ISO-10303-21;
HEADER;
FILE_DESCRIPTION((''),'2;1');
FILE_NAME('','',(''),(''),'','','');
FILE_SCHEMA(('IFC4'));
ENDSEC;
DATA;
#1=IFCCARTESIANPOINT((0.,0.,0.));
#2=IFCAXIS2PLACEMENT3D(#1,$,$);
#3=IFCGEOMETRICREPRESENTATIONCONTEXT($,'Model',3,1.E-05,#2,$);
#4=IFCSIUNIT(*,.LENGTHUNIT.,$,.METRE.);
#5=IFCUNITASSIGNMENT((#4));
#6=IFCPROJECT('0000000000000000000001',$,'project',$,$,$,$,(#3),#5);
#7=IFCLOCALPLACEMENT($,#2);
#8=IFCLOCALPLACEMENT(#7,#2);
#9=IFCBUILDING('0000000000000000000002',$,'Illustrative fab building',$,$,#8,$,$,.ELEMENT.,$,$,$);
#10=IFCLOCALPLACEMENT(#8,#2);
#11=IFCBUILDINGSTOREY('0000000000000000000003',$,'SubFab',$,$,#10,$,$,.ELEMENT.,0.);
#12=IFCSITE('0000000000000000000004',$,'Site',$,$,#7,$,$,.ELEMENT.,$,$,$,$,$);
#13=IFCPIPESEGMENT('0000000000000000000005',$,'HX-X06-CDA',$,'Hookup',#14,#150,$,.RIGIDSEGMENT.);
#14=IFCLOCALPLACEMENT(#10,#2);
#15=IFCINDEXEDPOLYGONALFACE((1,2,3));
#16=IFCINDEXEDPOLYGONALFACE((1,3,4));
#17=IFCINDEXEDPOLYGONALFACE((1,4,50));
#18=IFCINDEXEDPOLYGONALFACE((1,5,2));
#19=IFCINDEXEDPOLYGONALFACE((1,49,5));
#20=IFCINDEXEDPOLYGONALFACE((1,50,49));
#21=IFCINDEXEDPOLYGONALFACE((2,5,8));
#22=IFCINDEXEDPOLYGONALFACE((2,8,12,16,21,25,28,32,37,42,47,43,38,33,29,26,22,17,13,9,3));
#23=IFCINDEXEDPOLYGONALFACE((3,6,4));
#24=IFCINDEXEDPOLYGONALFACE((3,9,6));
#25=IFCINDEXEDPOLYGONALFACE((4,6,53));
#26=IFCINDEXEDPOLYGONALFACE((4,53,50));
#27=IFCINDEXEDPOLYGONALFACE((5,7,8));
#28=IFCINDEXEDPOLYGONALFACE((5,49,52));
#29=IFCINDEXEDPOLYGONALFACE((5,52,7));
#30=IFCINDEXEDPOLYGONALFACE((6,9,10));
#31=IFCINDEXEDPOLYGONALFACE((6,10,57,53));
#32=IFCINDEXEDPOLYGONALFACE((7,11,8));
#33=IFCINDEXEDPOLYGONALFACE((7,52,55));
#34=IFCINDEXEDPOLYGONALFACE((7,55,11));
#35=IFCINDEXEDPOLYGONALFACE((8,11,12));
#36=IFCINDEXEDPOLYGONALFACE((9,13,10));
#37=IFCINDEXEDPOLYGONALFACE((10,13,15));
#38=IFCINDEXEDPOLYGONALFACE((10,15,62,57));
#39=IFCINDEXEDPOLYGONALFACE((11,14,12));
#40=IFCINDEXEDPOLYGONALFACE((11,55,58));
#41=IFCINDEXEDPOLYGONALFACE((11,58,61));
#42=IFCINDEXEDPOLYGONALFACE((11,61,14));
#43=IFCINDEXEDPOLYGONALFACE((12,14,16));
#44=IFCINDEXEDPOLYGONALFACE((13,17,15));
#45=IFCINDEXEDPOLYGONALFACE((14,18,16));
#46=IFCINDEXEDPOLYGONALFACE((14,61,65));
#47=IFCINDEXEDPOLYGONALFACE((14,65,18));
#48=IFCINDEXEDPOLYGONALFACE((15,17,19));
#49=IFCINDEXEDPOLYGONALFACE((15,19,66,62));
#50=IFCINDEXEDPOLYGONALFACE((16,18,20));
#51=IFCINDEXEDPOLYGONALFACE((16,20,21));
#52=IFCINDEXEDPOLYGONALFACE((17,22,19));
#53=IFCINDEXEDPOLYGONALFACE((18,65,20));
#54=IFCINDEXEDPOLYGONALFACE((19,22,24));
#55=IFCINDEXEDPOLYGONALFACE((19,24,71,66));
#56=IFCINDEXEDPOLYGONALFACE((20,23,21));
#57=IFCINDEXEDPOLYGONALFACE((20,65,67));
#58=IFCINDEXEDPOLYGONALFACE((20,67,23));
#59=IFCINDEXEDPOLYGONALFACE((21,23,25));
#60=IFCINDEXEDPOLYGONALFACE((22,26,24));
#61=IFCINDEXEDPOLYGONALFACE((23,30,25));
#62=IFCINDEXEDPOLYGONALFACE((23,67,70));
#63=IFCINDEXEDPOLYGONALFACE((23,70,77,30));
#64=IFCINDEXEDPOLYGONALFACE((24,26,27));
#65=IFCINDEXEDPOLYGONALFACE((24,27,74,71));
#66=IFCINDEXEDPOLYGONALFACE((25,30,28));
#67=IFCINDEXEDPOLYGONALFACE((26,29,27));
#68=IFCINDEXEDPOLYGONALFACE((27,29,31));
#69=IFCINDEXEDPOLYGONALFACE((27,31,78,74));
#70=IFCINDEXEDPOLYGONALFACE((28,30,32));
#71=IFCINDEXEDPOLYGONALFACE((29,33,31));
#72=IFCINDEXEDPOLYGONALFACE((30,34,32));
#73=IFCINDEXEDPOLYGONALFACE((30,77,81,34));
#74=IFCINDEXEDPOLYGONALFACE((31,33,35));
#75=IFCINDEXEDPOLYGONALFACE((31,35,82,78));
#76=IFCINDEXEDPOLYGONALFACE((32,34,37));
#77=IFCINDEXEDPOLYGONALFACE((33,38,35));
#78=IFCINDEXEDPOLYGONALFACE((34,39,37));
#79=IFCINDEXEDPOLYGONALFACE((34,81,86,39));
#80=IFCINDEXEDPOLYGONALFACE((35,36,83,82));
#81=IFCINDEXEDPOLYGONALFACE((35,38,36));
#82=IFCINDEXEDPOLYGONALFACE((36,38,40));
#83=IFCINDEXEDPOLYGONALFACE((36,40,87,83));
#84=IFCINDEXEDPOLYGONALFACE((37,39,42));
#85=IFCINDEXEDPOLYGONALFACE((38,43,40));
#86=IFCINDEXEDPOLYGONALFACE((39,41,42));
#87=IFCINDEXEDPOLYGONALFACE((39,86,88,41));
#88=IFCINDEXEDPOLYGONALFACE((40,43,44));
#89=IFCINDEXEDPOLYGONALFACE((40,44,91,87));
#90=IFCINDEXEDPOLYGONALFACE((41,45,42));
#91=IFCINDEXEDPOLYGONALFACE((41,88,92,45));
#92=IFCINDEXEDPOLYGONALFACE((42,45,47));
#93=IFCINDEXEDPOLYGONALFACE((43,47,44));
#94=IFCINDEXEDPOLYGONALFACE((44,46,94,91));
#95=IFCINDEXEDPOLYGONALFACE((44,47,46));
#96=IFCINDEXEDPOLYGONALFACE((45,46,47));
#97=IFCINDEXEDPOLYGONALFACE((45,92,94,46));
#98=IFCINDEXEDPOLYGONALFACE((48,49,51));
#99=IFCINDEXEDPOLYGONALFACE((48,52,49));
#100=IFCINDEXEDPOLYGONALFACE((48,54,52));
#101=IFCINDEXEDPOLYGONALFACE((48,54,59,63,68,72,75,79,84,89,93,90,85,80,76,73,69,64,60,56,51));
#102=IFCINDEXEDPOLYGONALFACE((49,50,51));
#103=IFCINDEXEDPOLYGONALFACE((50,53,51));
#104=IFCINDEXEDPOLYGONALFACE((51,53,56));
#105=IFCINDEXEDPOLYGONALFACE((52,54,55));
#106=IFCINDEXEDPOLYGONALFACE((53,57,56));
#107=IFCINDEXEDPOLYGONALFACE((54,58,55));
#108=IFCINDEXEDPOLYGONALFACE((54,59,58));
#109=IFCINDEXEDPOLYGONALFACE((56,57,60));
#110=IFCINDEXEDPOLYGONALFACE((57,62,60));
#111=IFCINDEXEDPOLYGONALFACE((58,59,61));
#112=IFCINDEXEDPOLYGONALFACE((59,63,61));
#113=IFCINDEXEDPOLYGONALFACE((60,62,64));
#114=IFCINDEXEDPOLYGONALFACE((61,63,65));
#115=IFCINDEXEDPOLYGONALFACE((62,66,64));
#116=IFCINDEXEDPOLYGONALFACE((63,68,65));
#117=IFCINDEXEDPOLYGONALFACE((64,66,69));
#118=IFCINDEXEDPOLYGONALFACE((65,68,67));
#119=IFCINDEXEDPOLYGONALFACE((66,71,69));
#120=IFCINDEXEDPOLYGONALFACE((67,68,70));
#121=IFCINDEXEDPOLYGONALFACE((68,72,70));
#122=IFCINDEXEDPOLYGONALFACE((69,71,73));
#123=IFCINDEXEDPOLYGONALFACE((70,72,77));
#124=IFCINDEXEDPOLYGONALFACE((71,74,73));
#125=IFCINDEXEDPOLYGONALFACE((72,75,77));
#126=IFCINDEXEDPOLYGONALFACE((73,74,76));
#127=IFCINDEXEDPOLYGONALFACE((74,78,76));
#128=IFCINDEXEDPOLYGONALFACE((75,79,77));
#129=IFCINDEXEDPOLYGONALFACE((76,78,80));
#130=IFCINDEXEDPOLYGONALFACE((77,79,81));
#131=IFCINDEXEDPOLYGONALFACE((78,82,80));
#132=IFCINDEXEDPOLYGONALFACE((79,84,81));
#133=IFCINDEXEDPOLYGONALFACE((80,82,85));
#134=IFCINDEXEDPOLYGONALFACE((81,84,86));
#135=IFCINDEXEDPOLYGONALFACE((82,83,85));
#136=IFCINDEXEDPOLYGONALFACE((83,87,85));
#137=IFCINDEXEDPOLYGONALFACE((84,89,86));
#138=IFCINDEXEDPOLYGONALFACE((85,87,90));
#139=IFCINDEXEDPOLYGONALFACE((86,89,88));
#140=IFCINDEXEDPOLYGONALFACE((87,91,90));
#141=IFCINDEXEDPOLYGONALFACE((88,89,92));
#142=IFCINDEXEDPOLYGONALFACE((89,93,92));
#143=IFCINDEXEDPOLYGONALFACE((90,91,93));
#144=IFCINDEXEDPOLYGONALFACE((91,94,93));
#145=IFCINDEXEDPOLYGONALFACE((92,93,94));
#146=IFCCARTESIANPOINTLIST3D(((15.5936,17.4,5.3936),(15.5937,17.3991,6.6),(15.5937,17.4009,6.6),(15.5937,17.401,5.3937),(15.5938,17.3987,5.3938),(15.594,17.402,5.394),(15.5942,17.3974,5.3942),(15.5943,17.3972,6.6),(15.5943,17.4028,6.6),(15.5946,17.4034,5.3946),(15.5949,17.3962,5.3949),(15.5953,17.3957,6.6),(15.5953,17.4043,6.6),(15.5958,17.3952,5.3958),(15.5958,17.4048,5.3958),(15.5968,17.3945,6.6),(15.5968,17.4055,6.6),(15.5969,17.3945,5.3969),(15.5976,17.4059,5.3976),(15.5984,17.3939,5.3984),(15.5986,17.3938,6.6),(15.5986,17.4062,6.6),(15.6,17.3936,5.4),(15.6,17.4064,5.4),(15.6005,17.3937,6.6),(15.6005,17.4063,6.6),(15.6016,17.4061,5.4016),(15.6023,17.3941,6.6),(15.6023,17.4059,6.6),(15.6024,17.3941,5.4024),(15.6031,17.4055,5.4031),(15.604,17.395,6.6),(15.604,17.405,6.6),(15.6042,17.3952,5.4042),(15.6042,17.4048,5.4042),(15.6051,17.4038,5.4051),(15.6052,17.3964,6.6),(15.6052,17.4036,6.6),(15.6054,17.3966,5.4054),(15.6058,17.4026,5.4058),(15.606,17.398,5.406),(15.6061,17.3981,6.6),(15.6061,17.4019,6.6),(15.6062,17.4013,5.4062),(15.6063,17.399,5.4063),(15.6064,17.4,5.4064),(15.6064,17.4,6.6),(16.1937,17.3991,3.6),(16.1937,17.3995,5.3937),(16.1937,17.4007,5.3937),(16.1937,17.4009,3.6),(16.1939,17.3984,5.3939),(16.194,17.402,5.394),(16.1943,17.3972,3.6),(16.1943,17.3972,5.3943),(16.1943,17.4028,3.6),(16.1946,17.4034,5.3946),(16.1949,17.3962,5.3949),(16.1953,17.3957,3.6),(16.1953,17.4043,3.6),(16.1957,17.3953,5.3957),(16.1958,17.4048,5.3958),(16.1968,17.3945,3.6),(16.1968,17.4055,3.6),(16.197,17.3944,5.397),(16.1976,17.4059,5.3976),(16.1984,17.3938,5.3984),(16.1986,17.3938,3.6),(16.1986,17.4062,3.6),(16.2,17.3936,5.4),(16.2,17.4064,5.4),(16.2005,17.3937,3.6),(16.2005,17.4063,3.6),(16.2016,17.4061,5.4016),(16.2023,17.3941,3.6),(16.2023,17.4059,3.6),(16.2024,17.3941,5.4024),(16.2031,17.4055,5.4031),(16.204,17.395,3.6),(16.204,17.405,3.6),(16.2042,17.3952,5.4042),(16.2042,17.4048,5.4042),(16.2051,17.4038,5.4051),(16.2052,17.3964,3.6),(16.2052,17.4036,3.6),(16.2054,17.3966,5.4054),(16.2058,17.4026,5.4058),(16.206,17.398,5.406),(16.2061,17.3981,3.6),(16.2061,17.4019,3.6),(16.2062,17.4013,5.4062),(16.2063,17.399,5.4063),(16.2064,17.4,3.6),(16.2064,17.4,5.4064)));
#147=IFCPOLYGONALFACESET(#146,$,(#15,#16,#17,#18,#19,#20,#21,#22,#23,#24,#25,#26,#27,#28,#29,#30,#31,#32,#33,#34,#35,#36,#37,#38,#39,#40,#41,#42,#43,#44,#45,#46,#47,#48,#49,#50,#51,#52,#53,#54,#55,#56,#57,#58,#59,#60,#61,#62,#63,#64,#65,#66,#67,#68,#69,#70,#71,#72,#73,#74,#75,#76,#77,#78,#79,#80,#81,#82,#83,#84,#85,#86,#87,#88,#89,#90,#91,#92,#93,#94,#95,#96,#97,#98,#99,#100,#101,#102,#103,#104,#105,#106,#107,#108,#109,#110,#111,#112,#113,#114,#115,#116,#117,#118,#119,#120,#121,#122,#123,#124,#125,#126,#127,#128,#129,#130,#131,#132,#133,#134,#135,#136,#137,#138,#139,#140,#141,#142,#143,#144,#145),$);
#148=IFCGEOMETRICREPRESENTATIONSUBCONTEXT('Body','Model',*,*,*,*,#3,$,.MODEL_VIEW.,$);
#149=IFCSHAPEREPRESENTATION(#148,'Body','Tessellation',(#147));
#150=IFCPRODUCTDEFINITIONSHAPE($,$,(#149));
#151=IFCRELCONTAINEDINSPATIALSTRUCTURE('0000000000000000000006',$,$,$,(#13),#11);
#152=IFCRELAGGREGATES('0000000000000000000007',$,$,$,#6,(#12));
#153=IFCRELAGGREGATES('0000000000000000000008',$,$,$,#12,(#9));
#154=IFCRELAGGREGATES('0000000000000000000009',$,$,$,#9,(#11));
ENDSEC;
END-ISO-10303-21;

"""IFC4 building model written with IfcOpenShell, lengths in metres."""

from ifc_helpers import new_model, entity, si_unit, origin, place, context, subcontext, project, spatial, element, save


model = new_model("IFC4")

# Units and contexts
model_context = context("Model", 3, precision=1e-05, world=origin())
body_context = subcontext(model_context, "Body", "Model", "MODEL_VIEW")
ifc_project = project(units=[si_unit("LENGTHUNIT", "METRE")], contexts=[model_context])

# Site, building, storey
site_placement = place(None, origin())
site = spatial("IfcSite", under=ifc_project, at=site_placement, Name="Site", CompositionType="ELEMENT")
building_placement = place(site_placement, origin())
building = spatial("IfcBuilding", under=site, at=building_placement, Name="Illustrative fab building", CompositionType="ELEMENT")
storey_placement = place(building_placement, origin())
storey = spatial("IfcBuildingStorey", under=building, at=storey_placement, Name="SubFab", CompositionType="ELEMENT", Elevation=0.0)

# Pipe segment
pipe_segment_1_placement = place(storey_placement, origin())
element("IfcPipeSegment", 1, at=pipe_segment_1_placement, inside=storey, Name="HX-X06-CDA", ObjectType="Hookup", PredefinedType="RIGIDSEGMENT", context=body_context, shape_type="AdvancedSweptSolid", body=[
    entity("IfcSweptDiskSolid", entity("IfcPolyline", [entity("IfcCartesianPoint", [16.2, 17.4, 3.6]), entity("IfcCartesianPoint", [16.2, 17.4, 5.4]), entity("IfcCartesianPoint", [15.6, 17.4, 5.4]), entity("IfcCartesianPoint", [15.6, 17.4, 6.6])]), 0.0063),
])

save(model, "model.ifc")
